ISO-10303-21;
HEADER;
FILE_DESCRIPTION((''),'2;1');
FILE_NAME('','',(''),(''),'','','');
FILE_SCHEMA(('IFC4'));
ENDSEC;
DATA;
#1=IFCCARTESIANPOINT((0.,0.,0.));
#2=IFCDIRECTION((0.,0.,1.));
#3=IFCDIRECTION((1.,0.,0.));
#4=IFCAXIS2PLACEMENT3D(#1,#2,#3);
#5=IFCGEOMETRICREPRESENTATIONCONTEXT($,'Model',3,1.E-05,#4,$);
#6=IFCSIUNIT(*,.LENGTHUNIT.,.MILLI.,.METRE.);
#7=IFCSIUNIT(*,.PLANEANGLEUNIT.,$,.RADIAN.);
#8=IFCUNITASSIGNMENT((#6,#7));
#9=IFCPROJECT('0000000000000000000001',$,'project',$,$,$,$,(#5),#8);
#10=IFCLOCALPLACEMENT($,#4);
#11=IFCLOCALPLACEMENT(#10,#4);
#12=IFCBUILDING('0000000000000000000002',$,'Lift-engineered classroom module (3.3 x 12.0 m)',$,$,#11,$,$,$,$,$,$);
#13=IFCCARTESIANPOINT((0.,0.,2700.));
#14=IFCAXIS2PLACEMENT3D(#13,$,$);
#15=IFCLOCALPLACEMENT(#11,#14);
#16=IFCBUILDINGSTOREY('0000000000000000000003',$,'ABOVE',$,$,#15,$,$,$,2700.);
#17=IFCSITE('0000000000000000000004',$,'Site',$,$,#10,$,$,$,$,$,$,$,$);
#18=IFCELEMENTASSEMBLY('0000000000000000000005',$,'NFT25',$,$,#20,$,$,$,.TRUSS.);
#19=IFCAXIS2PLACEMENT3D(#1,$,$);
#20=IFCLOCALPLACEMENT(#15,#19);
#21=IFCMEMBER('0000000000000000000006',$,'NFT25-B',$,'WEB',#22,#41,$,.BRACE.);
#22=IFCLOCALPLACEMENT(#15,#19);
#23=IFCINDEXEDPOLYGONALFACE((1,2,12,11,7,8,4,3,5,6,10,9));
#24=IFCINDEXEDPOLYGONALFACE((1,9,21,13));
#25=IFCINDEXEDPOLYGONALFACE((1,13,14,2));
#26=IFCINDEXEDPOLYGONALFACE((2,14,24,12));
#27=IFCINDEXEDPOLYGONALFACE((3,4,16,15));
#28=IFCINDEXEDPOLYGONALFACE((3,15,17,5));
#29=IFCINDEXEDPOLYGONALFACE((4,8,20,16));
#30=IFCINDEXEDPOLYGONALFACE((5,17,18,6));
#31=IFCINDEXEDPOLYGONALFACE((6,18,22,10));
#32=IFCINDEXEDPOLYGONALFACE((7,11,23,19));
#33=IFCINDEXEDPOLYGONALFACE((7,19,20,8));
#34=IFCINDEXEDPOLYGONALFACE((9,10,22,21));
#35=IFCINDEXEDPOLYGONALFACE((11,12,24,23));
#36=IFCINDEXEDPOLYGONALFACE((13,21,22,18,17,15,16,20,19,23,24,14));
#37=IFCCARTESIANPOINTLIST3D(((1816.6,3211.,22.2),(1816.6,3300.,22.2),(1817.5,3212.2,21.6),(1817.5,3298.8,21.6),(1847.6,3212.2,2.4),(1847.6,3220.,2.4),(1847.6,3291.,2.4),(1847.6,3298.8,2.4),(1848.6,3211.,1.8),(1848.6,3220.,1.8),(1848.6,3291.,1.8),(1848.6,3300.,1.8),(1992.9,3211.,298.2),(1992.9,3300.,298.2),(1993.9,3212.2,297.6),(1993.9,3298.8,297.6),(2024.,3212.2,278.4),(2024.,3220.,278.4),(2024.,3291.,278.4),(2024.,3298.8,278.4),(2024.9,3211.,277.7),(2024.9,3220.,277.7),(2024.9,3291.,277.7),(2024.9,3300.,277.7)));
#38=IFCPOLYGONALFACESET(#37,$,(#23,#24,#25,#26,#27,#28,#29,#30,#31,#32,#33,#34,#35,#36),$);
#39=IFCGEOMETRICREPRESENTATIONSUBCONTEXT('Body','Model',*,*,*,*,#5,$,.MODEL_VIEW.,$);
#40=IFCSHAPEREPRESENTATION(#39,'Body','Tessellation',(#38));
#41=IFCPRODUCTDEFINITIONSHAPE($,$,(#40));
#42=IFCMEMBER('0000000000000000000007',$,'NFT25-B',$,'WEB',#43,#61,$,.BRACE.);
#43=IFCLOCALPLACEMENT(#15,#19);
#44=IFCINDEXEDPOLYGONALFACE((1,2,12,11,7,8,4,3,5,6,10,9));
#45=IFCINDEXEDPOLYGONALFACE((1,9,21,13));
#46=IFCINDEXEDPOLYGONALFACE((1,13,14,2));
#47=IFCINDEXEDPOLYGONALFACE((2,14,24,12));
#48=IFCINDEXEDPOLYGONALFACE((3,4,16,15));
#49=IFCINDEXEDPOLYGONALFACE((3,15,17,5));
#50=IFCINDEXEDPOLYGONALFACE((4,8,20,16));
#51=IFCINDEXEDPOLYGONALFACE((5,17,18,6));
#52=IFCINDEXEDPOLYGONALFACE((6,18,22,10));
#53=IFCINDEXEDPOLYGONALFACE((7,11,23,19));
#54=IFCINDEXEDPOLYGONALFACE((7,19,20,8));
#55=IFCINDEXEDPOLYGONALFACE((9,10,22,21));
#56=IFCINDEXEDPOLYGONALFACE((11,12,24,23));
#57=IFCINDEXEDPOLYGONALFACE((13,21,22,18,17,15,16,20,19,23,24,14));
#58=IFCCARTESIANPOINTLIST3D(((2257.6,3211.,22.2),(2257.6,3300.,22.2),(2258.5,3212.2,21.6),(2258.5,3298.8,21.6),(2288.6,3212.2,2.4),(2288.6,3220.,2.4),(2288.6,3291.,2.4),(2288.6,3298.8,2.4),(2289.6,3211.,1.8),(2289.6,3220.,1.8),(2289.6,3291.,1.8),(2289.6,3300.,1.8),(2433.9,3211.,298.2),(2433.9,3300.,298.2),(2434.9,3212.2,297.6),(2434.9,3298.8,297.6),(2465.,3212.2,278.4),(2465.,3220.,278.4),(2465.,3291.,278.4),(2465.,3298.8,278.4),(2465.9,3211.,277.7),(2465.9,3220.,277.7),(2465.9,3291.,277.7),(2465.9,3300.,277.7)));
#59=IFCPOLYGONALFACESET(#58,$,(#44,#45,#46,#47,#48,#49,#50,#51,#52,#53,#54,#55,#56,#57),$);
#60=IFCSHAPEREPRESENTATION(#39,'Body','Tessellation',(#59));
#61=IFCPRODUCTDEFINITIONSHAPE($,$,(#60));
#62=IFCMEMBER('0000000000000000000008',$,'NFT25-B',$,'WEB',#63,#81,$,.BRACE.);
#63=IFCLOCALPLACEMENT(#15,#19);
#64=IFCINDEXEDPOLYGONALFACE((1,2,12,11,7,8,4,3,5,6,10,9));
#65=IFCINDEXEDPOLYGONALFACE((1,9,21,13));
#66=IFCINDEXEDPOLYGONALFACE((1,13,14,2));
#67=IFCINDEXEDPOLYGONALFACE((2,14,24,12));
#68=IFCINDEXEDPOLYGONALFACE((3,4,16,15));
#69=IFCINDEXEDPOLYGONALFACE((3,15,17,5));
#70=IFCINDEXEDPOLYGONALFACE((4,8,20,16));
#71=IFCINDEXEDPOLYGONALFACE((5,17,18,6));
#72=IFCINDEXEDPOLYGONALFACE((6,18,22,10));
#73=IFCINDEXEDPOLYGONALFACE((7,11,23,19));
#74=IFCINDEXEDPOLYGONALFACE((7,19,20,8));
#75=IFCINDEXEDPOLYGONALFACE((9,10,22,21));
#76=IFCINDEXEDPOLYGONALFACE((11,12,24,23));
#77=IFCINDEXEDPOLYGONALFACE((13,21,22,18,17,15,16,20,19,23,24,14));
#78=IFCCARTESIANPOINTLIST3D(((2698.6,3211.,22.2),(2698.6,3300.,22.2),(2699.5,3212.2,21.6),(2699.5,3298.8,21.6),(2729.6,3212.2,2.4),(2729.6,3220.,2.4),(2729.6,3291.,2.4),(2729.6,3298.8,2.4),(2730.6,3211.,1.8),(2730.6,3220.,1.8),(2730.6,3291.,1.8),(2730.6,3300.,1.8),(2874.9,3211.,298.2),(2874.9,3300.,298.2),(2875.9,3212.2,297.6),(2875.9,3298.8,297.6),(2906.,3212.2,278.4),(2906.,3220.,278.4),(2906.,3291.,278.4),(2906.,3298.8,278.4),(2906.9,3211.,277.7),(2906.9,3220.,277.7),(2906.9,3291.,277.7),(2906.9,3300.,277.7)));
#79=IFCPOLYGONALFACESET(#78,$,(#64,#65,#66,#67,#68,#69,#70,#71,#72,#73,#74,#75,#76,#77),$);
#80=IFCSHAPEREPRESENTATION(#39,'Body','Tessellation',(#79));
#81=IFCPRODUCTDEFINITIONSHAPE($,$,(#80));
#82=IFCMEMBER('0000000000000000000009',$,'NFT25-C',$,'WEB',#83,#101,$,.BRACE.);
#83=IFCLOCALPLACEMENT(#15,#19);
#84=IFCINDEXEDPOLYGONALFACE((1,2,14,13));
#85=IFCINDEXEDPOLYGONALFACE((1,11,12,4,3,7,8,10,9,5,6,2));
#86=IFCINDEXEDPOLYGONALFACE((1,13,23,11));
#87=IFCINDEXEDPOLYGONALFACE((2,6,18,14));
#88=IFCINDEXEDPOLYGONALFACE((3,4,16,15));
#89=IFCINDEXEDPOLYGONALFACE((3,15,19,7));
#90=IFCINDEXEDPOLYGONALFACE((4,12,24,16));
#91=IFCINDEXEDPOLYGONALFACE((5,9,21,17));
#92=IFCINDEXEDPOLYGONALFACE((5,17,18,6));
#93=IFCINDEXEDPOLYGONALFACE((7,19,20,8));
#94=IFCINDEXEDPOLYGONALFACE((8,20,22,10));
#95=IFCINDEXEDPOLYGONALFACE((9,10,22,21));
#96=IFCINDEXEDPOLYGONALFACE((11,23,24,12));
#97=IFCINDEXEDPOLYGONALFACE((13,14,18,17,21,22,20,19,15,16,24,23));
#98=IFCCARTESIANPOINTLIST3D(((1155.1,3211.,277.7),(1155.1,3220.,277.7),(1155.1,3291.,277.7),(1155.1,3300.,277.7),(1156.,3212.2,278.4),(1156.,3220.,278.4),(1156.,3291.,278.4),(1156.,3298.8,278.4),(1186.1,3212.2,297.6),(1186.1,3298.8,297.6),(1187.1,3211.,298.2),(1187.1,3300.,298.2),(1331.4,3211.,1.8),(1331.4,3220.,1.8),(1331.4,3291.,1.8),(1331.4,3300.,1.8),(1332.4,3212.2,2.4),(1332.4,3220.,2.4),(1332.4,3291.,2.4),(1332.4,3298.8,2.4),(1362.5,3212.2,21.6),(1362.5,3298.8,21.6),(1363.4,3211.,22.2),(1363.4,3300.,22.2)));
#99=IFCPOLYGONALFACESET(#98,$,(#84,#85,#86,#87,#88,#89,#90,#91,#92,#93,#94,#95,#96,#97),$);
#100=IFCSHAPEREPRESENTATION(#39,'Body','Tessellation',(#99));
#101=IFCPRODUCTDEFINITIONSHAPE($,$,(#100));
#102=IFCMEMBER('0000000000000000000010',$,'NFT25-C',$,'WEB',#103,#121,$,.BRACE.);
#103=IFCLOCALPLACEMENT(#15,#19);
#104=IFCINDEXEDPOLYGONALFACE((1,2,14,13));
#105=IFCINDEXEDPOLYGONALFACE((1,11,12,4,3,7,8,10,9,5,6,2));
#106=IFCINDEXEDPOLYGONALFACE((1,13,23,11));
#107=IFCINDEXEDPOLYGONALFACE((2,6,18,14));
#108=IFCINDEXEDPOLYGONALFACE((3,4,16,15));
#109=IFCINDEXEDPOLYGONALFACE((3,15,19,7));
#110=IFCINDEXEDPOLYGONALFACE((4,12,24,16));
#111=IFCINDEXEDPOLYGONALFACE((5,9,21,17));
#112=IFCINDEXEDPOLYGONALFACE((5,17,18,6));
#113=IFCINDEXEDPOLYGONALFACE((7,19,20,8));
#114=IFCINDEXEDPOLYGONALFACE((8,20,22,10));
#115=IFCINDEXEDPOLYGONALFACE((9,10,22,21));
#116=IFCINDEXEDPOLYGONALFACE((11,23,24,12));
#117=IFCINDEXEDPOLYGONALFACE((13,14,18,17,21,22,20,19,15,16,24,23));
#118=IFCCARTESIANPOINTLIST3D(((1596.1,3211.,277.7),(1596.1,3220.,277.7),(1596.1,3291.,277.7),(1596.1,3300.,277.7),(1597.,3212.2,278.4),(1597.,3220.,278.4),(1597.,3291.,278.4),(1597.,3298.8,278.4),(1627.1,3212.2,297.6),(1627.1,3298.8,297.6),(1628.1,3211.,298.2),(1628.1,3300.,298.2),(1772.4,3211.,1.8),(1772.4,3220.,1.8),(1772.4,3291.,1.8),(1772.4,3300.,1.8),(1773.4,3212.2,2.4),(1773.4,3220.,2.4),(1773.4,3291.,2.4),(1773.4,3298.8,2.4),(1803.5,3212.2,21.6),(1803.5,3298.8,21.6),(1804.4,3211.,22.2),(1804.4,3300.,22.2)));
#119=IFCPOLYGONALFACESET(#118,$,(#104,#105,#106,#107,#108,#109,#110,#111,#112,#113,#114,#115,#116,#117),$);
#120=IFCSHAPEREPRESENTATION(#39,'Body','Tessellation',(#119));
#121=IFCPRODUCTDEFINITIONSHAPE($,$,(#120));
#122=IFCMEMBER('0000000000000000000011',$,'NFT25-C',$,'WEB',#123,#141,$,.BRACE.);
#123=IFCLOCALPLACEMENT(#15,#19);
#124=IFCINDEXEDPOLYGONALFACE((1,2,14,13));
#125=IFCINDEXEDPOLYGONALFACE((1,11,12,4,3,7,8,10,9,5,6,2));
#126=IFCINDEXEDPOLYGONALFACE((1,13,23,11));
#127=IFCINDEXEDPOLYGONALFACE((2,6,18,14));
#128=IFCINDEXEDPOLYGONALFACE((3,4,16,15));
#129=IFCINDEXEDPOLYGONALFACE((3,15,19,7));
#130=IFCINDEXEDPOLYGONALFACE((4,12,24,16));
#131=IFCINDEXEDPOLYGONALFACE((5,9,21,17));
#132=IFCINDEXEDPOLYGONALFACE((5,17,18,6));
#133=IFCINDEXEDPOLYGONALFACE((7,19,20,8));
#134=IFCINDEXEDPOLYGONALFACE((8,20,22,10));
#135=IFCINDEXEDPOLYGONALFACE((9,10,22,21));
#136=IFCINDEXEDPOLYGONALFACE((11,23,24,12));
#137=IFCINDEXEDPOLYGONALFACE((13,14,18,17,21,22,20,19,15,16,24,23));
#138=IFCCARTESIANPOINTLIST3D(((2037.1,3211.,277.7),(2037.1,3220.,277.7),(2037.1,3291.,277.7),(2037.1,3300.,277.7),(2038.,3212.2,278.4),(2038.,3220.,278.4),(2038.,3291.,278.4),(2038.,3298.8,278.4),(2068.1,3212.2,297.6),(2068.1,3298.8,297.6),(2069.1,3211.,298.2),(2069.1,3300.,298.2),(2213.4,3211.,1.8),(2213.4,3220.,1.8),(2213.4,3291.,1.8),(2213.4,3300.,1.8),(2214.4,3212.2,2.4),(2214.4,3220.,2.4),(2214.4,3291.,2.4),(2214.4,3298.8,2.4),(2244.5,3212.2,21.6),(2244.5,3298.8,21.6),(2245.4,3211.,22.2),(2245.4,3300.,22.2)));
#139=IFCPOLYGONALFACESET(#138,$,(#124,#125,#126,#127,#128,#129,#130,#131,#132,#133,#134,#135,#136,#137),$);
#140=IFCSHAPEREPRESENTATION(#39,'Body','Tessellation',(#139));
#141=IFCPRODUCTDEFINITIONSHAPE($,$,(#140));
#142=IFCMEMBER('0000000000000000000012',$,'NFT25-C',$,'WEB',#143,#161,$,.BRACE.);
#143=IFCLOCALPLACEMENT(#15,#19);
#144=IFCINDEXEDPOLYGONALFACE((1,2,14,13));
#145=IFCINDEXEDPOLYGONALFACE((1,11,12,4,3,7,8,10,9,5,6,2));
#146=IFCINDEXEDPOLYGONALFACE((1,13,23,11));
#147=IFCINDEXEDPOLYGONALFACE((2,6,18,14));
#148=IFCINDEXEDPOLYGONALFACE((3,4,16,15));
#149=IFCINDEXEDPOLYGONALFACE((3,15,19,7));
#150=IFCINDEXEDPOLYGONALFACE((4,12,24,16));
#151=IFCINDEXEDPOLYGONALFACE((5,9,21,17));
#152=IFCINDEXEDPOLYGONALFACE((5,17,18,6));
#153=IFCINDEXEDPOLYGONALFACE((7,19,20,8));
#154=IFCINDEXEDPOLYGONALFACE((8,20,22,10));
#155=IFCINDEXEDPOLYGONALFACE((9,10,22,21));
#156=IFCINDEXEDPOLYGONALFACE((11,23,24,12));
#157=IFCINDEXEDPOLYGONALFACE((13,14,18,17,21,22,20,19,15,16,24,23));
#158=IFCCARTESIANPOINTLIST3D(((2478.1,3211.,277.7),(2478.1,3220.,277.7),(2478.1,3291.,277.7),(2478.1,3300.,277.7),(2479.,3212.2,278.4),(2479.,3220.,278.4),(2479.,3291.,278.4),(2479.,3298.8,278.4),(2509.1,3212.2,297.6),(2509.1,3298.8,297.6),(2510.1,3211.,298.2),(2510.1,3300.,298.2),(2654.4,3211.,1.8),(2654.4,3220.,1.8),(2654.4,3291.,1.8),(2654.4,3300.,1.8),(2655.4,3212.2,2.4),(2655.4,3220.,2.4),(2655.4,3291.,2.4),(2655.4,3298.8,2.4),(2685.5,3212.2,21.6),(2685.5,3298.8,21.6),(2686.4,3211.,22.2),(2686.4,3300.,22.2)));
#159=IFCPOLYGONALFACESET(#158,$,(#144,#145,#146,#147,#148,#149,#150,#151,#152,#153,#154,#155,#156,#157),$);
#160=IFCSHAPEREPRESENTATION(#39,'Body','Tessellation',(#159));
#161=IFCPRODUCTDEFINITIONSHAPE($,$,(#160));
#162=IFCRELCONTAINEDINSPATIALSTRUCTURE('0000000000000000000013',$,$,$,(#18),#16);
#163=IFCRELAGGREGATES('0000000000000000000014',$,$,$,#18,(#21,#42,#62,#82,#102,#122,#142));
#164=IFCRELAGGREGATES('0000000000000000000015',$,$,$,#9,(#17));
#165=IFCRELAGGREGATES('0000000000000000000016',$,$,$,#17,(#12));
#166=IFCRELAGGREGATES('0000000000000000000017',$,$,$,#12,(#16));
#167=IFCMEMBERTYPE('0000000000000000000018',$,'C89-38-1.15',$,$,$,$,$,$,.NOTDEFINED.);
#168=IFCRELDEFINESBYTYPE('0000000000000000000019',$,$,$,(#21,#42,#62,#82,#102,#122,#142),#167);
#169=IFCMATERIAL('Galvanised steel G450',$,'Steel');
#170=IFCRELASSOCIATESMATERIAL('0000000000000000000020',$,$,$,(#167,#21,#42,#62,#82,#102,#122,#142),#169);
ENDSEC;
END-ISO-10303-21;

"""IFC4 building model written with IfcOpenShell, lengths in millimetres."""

from ifc_helpers import new_model, si_unit, frame, origin, origin_with_axes, origin_2d, place, context, subcontext, project, spatial, c_section, extrude, material, material_profile, profile_set, profile_usage, type_object, element, aggregate, save


model = new_model("IFC4")

# Units and contexts
model_context = context("Model", 3, precision=1e-05, world=origin_with_axes())
body_context = subcontext(model_context, "Body", "Model", "MODEL_VIEW")
ifc_project = project(units=[si_unit("LENGTHUNIT", "METRE", prefix="MILLI"), si_unit("PLANEANGLEUNIT", "RADIAN")], contexts=[model_context])

# Site, building, storey
site_placement = place(None, origin_with_axes())
site = spatial("IfcSite", under=ifc_project, at=site_placement, Name="Site")
building_placement = place(site_placement, origin_with_axes())
building = spatial("IfcBuilding", under=site, at=building_placement, Name="Lift-engineered classroom module (3.3 x 12.0 m)")
storey_placement = place(building_placement, frame((0.0, 0.0, 2700.0)))
storey = spatial("IfcBuildingStorey", under=building, at=storey_placement, Name="ABOVE", Elevation=2700.0)

# Element assembly, members
ifc_material = material(Name="Galvanised steel G450", Category="Steel")
assembly_1_placement = place(storey_placement, frame((0.0, 3255.5, 0.0)))
assembly_1 = element("IfcElementAssembly", 1, at=assembly_1_placement, inside=storey, Name="NFT25", PredefinedType="TRUSS")
ifc_material_profile_1 = material_profile(ifc_material, c_section(Depth=89.0, Width=38.0, WallThickness=1.1, Girth=9.0, at=origin_2d()), Name="C89-38-1.15")
ifc_profile_set_1 = profile_set([ifc_material_profile_1], Name="C89-38-1.15")
ifc_profile_usage_1 = profile_usage(ifc_profile_set_1)
member_type_1 = type_object("IfcMemberType", Name="C89-38-1.15", PredefinedType="NOTDEFINED", material=ifc_profile_set_1)
member_1_placement = place(assembly_1_placement, frame((1832.6, 0.0, 12.0), z_axis=(0.538459, 0.0, 0.842652), x_axis=(0.842652, 0.0, -0.538459)))
member_1 = element("IfcMember", 2, at=member_1_placement, type_object=member_type_1, material=ifc_profile_usage_1, Name="NFT25-B", ObjectType="WEB", PredefinedType="BRACE", context=body_context, shape_type="SweptSolid", body=[
    extrude(c_section(Depth=89.0, Width=38.0, WallThickness=1.1, Girth=9.0, at=origin_2d()), origin(), (0.0, 0.0, 1.0), 327.5),
])
member_2_placement = place(assembly_1_placement, frame((2273.6, 0.0, 12.0), z_axis=(0.538459, 0.0, 0.842652), x_axis=(0.842652, 0.0, -0.538459)))
member_2 = element("IfcMember", 3, at=member_2_placement, type_object=member_type_1, material=ifc_profile_usage_1, Name="NFT25-B", ObjectType="WEB", PredefinedType="BRACE", context=body_context, shape_type="SweptSolid", body=[
    extrude(c_section(Depth=89.0, Width=38.0, WallThickness=1.1, Girth=9.0, at=origin_2d()), origin(), (0.0, 0.0, 1.0), 327.5),
])
member_3_placement = place(assembly_1_placement, frame((2714.6, 0.0, 12.0), z_axis=(0.538459, 0.0, 0.842652), x_axis=(0.842652, 0.0, -0.538459)))
member_3 = element("IfcMember", 4, at=member_3_placement, type_object=member_type_1, material=ifc_profile_usage_1, Name="NFT25-B", ObjectType="WEB", PredefinedType="BRACE", context=body_context, shape_type="SweptSolid", body=[
    extrude(c_section(Depth=89.0, Width=38.0, WallThickness=1.1, Girth=9.0, at=origin_2d()), origin(), (0.0, 0.0, 1.0), 327.5),
])
member_4_placement = place(assembly_1_placement, frame((1347.4, 0.0, 12.0), z_axis=(-0.538459, 0.0, 0.842652), x_axis=(-0.842652, 0.0, -0.538459)))
member_4 = element("IfcMember", 5, at=member_4_placement, type_object=member_type_1, material=ifc_profile_usage_1, Name="NFT25-C", ObjectType="WEB", PredefinedType="BRACE", context=body_context, shape_type="SweptSolid", body=[
    extrude(c_section(Depth=89.0, Width=38.0, WallThickness=1.1, Girth=9.0, at=origin_2d()), origin(), (0.0, 0.0, 1.0), 327.5),
])
member_5_placement = place(assembly_1_placement, frame((1788.4, 0.0, 12.0), z_axis=(-0.538459, 0.0, 0.842652), x_axis=(-0.842652, 0.0, -0.538459)))
member_5 = element("IfcMember", 6, at=member_5_placement, type_object=member_type_1, material=ifc_profile_usage_1, Name="NFT25-C", ObjectType="WEB", PredefinedType="BRACE", context=body_context, shape_type="SweptSolid", body=[
    extrude(c_section(Depth=89.0, Width=38.0, WallThickness=1.1, Girth=9.0, at=origin_2d()), origin(), (0.0, 0.0, 1.0), 327.5),
])
member_6_placement = place(assembly_1_placement, frame((2229.4, 0.0, 12.0), z_axis=(-0.538459, 0.0, 0.842652), x_axis=(-0.842652, 0.0, -0.538459)))
member_6 = element("IfcMember", 7, at=member_6_placement, type_object=member_type_1, material=ifc_profile_usage_1, Name="NFT25-C", ObjectType="WEB", PredefinedType="BRACE", context=body_context, shape_type="SweptSolid", body=[
    extrude(c_section(Depth=89.0, Width=38.0, WallThickness=1.1, Girth=9.0, at=origin_2d()), origin(), (0.0, 0.0, 1.0), 327.5),
])
member_7_placement = place(assembly_1_placement, frame((2670.4, 0.0, 12.0), z_axis=(-0.538459, 0.0, 0.842652), x_axis=(-0.842652, 0.0, -0.538459)))
member_7 = element("IfcMember", 8, at=member_7_placement, type_object=member_type_1, material=ifc_profile_usage_1, Name="NFT25-C", ObjectType="WEB", PredefinedType="BRACE", context=body_context, shape_type="SweptSolid", body=[
    extrude(c_section(Depth=89.0, Width=38.0, WallThickness=1.1, Girth=9.0, at=origin_2d()), origin(), (0.0, 0.0, 1.0), 327.5),
])
aggregate(assembly_1, [member_1, member_2, member_3, member_4, member_5, member_6, member_7])

save(model, "model.ifc")
